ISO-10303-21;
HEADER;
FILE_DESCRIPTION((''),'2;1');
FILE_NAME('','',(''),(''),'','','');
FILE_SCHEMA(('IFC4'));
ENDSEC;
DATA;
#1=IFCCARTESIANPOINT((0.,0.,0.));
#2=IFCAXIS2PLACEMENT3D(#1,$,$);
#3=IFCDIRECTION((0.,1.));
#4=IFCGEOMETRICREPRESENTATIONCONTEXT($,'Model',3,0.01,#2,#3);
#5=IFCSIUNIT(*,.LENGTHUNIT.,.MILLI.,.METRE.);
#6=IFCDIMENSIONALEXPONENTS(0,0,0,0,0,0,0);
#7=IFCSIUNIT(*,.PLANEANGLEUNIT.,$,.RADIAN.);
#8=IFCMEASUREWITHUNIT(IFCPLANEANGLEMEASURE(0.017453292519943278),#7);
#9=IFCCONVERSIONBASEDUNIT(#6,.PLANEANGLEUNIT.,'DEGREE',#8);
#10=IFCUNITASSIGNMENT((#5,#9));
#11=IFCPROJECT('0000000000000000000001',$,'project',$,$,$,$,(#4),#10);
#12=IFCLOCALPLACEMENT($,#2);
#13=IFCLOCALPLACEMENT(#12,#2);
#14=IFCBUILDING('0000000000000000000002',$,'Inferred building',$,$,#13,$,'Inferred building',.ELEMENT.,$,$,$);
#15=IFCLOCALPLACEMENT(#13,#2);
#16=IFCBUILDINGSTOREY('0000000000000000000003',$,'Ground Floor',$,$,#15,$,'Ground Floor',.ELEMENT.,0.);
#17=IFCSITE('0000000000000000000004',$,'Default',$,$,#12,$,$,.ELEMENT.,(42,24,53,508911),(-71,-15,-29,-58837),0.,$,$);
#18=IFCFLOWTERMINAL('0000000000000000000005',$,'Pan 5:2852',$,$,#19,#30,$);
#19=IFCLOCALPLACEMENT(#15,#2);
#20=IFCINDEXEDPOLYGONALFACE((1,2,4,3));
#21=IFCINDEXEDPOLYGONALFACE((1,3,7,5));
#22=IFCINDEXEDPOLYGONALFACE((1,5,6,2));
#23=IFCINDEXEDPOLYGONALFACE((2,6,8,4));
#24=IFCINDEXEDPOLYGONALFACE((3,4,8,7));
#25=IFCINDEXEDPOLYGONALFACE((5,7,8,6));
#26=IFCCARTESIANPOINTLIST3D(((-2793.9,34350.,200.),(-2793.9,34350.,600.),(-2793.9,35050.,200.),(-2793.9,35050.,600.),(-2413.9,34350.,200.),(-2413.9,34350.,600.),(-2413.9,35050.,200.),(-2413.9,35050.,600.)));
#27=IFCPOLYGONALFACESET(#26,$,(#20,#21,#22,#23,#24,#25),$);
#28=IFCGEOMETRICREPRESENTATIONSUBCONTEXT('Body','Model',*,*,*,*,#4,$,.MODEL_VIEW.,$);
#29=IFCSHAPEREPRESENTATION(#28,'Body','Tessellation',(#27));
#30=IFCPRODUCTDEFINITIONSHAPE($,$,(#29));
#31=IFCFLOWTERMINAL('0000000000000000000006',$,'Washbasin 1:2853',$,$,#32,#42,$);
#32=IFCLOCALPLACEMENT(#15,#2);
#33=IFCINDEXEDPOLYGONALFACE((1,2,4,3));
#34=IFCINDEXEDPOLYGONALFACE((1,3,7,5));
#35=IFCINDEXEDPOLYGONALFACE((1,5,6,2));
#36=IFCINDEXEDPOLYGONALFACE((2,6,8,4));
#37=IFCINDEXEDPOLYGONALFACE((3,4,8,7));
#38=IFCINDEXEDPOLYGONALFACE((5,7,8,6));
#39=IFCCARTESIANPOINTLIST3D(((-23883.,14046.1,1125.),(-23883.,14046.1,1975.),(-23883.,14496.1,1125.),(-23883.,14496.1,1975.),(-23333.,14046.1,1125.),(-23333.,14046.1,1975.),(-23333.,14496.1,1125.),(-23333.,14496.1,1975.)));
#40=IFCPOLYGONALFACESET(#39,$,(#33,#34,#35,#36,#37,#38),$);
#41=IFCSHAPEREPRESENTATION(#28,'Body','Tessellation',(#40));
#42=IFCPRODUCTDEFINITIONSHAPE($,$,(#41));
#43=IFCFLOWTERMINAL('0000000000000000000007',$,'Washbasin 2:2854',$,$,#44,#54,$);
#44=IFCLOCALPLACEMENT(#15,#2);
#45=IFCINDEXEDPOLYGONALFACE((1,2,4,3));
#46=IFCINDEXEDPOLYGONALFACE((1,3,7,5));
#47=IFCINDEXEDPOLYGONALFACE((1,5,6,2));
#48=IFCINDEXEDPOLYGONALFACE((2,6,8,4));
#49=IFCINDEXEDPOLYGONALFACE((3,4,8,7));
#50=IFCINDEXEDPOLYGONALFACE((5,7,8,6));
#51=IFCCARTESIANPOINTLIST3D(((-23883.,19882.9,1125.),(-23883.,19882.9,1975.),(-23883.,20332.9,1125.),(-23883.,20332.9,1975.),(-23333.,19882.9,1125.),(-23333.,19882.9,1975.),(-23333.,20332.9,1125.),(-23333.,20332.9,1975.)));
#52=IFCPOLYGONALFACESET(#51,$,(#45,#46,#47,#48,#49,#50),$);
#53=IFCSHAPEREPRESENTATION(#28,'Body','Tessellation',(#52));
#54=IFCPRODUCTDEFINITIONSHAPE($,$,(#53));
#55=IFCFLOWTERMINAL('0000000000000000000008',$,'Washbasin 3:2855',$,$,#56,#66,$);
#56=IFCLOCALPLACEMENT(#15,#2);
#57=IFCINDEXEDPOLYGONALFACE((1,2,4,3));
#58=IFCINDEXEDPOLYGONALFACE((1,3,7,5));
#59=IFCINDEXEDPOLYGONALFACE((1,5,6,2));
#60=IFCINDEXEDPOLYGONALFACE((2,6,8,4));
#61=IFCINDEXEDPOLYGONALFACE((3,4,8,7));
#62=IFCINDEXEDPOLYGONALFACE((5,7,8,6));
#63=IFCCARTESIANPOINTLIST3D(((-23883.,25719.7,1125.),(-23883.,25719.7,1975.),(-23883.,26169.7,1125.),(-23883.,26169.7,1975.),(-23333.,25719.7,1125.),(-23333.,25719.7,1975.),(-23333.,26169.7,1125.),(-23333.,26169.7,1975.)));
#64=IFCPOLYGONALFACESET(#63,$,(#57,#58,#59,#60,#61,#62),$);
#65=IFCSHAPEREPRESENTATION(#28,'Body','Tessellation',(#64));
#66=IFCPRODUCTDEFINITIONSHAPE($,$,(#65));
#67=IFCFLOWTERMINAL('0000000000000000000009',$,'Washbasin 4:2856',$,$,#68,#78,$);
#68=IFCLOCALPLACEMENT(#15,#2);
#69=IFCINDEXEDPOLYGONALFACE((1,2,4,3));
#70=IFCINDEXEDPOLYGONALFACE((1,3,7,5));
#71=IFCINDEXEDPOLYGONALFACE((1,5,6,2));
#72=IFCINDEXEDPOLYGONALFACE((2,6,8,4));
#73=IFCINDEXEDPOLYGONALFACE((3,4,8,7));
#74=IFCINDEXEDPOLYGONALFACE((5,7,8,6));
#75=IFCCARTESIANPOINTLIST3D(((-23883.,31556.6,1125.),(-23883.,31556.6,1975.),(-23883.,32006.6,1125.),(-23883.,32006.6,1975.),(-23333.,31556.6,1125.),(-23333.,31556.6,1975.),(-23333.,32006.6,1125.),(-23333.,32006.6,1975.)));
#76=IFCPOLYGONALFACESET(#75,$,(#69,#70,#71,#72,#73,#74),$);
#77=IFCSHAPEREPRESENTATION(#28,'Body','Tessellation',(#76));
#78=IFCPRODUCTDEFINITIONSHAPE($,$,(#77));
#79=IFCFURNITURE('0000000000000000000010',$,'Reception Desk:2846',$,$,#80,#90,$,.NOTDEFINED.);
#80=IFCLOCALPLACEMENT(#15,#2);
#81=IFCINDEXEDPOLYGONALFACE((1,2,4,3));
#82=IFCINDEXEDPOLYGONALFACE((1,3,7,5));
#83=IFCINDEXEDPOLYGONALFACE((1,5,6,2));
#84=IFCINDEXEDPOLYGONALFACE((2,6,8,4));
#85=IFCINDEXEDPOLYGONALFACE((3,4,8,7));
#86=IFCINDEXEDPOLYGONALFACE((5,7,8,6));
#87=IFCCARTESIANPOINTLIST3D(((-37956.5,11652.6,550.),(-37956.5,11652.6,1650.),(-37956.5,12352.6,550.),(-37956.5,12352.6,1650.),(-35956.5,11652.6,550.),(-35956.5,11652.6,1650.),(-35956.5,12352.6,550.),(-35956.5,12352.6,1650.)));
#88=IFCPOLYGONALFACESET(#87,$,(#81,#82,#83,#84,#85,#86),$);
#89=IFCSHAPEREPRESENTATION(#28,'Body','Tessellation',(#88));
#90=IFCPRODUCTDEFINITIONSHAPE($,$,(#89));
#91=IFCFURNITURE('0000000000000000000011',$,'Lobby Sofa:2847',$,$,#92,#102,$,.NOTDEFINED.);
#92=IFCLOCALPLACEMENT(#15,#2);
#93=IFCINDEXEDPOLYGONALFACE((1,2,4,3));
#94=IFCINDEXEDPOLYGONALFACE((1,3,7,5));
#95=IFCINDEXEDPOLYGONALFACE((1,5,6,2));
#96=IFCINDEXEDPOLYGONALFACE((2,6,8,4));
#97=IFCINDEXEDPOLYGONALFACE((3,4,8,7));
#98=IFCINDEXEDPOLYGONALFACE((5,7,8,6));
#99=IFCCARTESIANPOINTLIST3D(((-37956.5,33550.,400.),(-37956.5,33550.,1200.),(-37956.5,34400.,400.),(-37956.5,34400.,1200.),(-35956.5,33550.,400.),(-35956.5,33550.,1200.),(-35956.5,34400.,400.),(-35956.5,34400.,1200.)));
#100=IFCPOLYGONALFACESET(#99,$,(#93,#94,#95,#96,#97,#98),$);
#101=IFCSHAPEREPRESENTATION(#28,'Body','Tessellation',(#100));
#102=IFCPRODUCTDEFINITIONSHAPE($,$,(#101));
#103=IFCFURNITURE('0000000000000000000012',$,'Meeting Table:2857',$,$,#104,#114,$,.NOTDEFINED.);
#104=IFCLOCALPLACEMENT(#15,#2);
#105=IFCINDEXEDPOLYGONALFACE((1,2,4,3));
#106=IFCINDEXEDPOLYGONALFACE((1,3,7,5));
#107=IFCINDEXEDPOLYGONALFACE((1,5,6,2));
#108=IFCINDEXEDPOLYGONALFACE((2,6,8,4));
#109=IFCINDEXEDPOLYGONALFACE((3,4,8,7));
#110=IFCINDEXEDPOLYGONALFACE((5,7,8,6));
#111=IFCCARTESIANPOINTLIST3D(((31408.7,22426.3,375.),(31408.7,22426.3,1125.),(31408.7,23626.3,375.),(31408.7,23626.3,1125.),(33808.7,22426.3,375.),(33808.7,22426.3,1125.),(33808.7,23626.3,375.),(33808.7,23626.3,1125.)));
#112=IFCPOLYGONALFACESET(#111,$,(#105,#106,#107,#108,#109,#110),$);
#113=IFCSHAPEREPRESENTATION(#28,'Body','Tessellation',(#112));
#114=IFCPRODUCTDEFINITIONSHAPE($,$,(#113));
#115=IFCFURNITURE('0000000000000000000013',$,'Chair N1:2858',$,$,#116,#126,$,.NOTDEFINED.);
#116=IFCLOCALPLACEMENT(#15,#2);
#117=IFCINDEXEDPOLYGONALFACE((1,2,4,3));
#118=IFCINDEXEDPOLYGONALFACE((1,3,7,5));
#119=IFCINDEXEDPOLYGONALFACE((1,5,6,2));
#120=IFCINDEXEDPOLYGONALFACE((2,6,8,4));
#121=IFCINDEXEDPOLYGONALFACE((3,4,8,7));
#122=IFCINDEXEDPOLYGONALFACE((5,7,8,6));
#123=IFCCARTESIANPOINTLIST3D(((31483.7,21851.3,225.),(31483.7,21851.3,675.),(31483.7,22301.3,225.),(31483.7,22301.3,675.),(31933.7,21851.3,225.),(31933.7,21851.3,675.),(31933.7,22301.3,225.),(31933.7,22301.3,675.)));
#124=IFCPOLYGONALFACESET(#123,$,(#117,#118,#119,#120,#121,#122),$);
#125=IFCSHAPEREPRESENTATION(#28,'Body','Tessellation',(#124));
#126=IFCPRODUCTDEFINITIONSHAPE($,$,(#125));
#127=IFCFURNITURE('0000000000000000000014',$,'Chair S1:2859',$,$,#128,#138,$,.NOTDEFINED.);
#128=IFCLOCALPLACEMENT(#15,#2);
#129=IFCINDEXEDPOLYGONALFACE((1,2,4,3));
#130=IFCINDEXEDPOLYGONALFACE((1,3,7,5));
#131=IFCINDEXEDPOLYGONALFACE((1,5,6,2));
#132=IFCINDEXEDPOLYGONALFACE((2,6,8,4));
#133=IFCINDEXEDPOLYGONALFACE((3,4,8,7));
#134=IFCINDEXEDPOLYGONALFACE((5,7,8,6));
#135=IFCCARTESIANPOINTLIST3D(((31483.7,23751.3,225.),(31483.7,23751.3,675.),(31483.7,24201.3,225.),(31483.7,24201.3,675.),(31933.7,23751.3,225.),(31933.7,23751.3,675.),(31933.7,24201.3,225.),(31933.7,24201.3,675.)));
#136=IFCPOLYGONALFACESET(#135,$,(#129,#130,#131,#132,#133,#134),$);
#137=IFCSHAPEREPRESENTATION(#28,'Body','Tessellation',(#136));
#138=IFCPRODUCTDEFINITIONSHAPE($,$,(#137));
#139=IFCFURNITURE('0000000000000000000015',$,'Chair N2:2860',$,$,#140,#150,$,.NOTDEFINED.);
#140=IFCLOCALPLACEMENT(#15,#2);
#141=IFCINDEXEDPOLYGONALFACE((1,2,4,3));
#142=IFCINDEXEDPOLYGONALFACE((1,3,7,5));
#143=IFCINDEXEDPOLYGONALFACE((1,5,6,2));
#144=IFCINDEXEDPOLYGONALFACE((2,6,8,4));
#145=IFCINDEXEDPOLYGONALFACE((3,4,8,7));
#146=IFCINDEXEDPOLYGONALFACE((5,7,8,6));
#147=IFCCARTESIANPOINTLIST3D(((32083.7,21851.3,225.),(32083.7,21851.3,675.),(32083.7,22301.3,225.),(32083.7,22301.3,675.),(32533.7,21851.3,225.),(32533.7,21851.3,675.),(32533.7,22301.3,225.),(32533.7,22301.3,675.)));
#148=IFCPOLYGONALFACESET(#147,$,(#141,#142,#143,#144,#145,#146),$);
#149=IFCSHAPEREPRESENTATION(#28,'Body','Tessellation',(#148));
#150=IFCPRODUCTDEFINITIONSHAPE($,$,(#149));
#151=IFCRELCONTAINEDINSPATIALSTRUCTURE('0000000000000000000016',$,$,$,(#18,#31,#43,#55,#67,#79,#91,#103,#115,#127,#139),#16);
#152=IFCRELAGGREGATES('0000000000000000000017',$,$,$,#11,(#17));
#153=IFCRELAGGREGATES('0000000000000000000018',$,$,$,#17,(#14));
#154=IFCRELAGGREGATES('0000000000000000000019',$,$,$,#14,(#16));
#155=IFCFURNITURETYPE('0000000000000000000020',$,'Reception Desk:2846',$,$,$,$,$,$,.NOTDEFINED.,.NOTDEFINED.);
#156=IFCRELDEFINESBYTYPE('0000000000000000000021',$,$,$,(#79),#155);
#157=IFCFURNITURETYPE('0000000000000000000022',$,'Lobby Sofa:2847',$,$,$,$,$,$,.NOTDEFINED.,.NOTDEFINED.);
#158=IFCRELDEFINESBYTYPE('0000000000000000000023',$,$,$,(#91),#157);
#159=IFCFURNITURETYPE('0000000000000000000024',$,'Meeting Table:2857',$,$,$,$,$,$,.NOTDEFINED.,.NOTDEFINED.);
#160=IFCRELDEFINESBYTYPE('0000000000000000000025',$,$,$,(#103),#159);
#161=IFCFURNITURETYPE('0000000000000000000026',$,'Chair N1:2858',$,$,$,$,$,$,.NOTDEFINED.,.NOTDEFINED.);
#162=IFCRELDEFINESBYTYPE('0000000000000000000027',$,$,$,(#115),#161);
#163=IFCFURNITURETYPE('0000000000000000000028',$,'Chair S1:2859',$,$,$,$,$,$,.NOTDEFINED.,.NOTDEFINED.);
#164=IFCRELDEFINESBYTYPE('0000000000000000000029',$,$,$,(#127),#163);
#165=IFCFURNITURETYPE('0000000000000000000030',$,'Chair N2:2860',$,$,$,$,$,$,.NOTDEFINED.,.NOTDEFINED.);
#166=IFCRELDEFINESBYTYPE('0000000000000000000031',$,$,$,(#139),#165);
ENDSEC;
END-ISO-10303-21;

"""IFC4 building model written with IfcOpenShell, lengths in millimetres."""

from ifc_helpers import new_model, entity, si_unit, converted_unit, direction, frame, origin, origin_2d_with_axis, place, context, subcontext, project, spatial, rectangle, extrude, type_object, element, save


model = new_model("IFC4")

# Units and contexts
model_context = context("Model", 3, precision=0.01, world=origin(), true_north=direction((0.0, 1.0)))
body_context = subcontext(model_context, "Body", "Model", "MODEL_VIEW")
ifc_project = project(units=[si_unit("LENGTHUNIT", "METRE", prefix="MILLI"), converted_unit("PLANEANGLEUNIT", "DEGREE", entity("IfcPlaneAngleMeasure", 0.017453292519943278), si_unit("PLANEANGLEUNIT", "RADIAN"), dimensions=[0, 0, 0, 0, 0, 0, 0])], contexts=[model_context])

# Site, building, storey
site_placement = place(None, origin())
site = spatial("IfcSite", under=ifc_project, at=site_placement, Name="Default", CompositionType="ELEMENT", RefLatitude=(42, 24, 53, 508911), RefLongitude=(-71, -15, -29, -58837), RefElevation=0.0)
building_placement = place(site_placement, origin())
building = spatial("IfcBuilding", under=site, at=building_placement, Name="Inferred building", LongName="Inferred building", CompositionType="ELEMENT")
storey_placement = place(building_placement, origin())
storey = spatial("IfcBuildingStorey", under=building, at=storey_placement, Name="Ground Floor", LongName="Ground Floor", CompositionType="ELEMENT", Elevation=0.0)

# Flow terminals
flow_terminal_1_placement = place(storey_placement, origin())
element("IfcFlowTerminal", 1, at=flow_terminal_1_placement, inside=storey, Name="Pan 5:2852", context=body_context, shape_type="SweptSolid", body=[
    extrude(rectangle(XDim=700.0, YDim=380.0, at=origin_2d_with_axis()), frame((-2603.9, 34700.0, 200.0), z_axis=(0.0, 0.0, 1.0), x_axis=(0.0, 1.0, 0.0)), (0.0, 0.0, 1.0), 400.0),
])
flow_terminal_2_placement = place(storey_placement, origin())
element("IfcFlowTerminal", 2, at=flow_terminal_2_placement, inside=storey, Name="Washbasin 1:2853", context=body_context, shape_type="SweptSolid", body=[
    extrude(rectangle(XDim=450.0, YDim=550.0, at=origin_2d_with_axis()), frame((-23608.0, 14271.1, 1125.0), z_axis=(0.0, 0.0, 1.0), x_axis=(0.0, 1.0, 0.0)), (0.0, 0.0, 1.0), 850.0),
])
flow_terminal_3_placement = place(storey_placement, origin())
element("IfcFlowTerminal", 3, at=flow_terminal_3_placement, inside=storey, Name="Washbasin 2:2854", context=body_context, shape_type="SweptSolid", body=[
    extrude(rectangle(XDim=450.0, YDim=550.0, at=origin_2d_with_axis()), frame((-23608.0, 20107.9, 1125.0), z_axis=(0.0, 0.0, 1.0), x_axis=(0.0, 1.0, 0.0)), (0.0, 0.0, 1.0), 850.0),
])
flow_terminal_4_placement = place(storey_placement, origin())
element("IfcFlowTerminal", 4, at=flow_terminal_4_placement, inside=storey, Name="Washbasin 3:2855", context=body_context, shape_type="SweptSolid", body=[
    extrude(rectangle(XDim=450.0, YDim=550.0, at=origin_2d_with_axis()), frame((-23608.0, 25944.7, 1125.0), z_axis=(0.0, 0.0, 1.0), x_axis=(0.0, 1.0, 0.0)), (0.0, 0.0, 1.0), 850.0),
])
flow_terminal_5_placement = place(storey_placement, origin())
element("IfcFlowTerminal", 5, at=flow_terminal_5_placement, inside=storey, Name="Washbasin 4:2856", context=body_context, shape_type="SweptSolid", body=[
    extrude(rectangle(XDim=450.0, YDim=550.0, at=origin_2d_with_axis()), frame((-23608.0, 31781.6, 1125.0), z_axis=(0.0, 0.0, 1.0), x_axis=(0.0, 1.0, 0.0)), (0.0, 0.0, 1.0), 850.0),
])

# Furniture
furniture_type_1 = type_object("IfcFurnitureType", Name="Reception Desk:2846", PredefinedType="NOTDEFINED")
furniture_1_placement = place(storey_placement, origin())
element("IfcFurniture", 6, at=furniture_1_placement, inside=storey, type_object=furniture_type_1, Name="Reception Desk:2846", PredefinedType="NOTDEFINED", context=body_context, shape_type="SweptSolid", body=[
    extrude(rectangle(XDim=2000.0, YDim=700.0, at=origin_2d_with_axis()), frame((-36956.5, 12002.6, 550.0)), (0.0, 0.0, 1.0), 1100.0),
])
furniture_type_2 = type_object("IfcFurnitureType", Name="Lobby Sofa:2847", PredefinedType="NOTDEFINED")
furniture_2_placement = place(storey_placement, origin())
element("IfcFurniture", 7, at=furniture_2_placement, inside=storey, type_object=furniture_type_2, Name="Lobby Sofa:2847", PredefinedType="NOTDEFINED", context=body_context, shape_type="SweptSolid", body=[
    extrude(rectangle(XDim=2000.0, YDim=850.0, at=origin_2d_with_axis()), frame((-36956.5, 33975.0, 400.0)), (0.0, 0.0, 1.0), 800.0),
])
furniture_type_3 = type_object("IfcFurnitureType", Name="Meeting Table:2857", PredefinedType="NOTDEFINED")
furniture_3_placement = place(storey_placement, origin())
element("IfcFurniture", 8, at=furniture_3_placement, inside=storey, type_object=furniture_type_3, Name="Meeting Table:2857", PredefinedType="NOTDEFINED", context=body_context, shape_type="SweptSolid", body=[
    extrude(rectangle(XDim=2400.0, YDim=1200.0, at=origin_2d_with_axis()), frame((32608.7, 23026.3, 375.0)), (0.0, 0.0, 1.0), 750.0),
])
furniture_type_4 = type_object("IfcFurnitureType", Name="Chair N1:2858", PredefinedType="NOTDEFINED")
furniture_4_placement = place(storey_placement, origin())
element("IfcFurniture", 9, at=furniture_4_placement, inside=storey, type_object=furniture_type_4, Name="Chair N1:2858", PredefinedType="NOTDEFINED", context=body_context, shape_type="SweptSolid", body=[
    extrude(rectangle(XDim=450.0, YDim=450.0, at=origin_2d_with_axis()), frame((31708.7, 22076.3, 225.0)), (0.0, 0.0, 1.0), 450.0),
])
furniture_type_5 = type_object("IfcFurnitureType", Name="Chair S1:2859", PredefinedType="NOTDEFINED")
furniture_5_placement = place(storey_placement, origin())
element("IfcFurniture", 10, at=furniture_5_placement, inside=storey, type_object=furniture_type_5, Name="Chair S1:2859", PredefinedType="NOTDEFINED", context=body_context, shape_type="SweptSolid", body=[
    extrude(rectangle(XDim=450.0, YDim=450.0, at=origin_2d_with_axis()), frame((31708.7, 23976.3, 225.0)), (0.0, 0.0, 1.0), 450.0),
])
furniture_type_6 = type_object("IfcFurnitureType", Name="Chair N2:2860", PredefinedType="NOTDEFINED")
furniture_6_placement = place(storey_placement, origin())
element("IfcFurniture", 11, at=furniture_6_placement, inside=storey, type_object=furniture_type_6, Name="Chair N2:2860", PredefinedType="NOTDEFINED", context=body_context, shape_type="SweptSolid", body=[
    extrude(rectangle(XDim=450.0, YDim=450.0, at=origin_2d_with_axis()), frame((32308.7, 22076.3, 225.0)), (0.0, 0.0, 1.0), 450.0),
])

save(model, "model.ifc")
